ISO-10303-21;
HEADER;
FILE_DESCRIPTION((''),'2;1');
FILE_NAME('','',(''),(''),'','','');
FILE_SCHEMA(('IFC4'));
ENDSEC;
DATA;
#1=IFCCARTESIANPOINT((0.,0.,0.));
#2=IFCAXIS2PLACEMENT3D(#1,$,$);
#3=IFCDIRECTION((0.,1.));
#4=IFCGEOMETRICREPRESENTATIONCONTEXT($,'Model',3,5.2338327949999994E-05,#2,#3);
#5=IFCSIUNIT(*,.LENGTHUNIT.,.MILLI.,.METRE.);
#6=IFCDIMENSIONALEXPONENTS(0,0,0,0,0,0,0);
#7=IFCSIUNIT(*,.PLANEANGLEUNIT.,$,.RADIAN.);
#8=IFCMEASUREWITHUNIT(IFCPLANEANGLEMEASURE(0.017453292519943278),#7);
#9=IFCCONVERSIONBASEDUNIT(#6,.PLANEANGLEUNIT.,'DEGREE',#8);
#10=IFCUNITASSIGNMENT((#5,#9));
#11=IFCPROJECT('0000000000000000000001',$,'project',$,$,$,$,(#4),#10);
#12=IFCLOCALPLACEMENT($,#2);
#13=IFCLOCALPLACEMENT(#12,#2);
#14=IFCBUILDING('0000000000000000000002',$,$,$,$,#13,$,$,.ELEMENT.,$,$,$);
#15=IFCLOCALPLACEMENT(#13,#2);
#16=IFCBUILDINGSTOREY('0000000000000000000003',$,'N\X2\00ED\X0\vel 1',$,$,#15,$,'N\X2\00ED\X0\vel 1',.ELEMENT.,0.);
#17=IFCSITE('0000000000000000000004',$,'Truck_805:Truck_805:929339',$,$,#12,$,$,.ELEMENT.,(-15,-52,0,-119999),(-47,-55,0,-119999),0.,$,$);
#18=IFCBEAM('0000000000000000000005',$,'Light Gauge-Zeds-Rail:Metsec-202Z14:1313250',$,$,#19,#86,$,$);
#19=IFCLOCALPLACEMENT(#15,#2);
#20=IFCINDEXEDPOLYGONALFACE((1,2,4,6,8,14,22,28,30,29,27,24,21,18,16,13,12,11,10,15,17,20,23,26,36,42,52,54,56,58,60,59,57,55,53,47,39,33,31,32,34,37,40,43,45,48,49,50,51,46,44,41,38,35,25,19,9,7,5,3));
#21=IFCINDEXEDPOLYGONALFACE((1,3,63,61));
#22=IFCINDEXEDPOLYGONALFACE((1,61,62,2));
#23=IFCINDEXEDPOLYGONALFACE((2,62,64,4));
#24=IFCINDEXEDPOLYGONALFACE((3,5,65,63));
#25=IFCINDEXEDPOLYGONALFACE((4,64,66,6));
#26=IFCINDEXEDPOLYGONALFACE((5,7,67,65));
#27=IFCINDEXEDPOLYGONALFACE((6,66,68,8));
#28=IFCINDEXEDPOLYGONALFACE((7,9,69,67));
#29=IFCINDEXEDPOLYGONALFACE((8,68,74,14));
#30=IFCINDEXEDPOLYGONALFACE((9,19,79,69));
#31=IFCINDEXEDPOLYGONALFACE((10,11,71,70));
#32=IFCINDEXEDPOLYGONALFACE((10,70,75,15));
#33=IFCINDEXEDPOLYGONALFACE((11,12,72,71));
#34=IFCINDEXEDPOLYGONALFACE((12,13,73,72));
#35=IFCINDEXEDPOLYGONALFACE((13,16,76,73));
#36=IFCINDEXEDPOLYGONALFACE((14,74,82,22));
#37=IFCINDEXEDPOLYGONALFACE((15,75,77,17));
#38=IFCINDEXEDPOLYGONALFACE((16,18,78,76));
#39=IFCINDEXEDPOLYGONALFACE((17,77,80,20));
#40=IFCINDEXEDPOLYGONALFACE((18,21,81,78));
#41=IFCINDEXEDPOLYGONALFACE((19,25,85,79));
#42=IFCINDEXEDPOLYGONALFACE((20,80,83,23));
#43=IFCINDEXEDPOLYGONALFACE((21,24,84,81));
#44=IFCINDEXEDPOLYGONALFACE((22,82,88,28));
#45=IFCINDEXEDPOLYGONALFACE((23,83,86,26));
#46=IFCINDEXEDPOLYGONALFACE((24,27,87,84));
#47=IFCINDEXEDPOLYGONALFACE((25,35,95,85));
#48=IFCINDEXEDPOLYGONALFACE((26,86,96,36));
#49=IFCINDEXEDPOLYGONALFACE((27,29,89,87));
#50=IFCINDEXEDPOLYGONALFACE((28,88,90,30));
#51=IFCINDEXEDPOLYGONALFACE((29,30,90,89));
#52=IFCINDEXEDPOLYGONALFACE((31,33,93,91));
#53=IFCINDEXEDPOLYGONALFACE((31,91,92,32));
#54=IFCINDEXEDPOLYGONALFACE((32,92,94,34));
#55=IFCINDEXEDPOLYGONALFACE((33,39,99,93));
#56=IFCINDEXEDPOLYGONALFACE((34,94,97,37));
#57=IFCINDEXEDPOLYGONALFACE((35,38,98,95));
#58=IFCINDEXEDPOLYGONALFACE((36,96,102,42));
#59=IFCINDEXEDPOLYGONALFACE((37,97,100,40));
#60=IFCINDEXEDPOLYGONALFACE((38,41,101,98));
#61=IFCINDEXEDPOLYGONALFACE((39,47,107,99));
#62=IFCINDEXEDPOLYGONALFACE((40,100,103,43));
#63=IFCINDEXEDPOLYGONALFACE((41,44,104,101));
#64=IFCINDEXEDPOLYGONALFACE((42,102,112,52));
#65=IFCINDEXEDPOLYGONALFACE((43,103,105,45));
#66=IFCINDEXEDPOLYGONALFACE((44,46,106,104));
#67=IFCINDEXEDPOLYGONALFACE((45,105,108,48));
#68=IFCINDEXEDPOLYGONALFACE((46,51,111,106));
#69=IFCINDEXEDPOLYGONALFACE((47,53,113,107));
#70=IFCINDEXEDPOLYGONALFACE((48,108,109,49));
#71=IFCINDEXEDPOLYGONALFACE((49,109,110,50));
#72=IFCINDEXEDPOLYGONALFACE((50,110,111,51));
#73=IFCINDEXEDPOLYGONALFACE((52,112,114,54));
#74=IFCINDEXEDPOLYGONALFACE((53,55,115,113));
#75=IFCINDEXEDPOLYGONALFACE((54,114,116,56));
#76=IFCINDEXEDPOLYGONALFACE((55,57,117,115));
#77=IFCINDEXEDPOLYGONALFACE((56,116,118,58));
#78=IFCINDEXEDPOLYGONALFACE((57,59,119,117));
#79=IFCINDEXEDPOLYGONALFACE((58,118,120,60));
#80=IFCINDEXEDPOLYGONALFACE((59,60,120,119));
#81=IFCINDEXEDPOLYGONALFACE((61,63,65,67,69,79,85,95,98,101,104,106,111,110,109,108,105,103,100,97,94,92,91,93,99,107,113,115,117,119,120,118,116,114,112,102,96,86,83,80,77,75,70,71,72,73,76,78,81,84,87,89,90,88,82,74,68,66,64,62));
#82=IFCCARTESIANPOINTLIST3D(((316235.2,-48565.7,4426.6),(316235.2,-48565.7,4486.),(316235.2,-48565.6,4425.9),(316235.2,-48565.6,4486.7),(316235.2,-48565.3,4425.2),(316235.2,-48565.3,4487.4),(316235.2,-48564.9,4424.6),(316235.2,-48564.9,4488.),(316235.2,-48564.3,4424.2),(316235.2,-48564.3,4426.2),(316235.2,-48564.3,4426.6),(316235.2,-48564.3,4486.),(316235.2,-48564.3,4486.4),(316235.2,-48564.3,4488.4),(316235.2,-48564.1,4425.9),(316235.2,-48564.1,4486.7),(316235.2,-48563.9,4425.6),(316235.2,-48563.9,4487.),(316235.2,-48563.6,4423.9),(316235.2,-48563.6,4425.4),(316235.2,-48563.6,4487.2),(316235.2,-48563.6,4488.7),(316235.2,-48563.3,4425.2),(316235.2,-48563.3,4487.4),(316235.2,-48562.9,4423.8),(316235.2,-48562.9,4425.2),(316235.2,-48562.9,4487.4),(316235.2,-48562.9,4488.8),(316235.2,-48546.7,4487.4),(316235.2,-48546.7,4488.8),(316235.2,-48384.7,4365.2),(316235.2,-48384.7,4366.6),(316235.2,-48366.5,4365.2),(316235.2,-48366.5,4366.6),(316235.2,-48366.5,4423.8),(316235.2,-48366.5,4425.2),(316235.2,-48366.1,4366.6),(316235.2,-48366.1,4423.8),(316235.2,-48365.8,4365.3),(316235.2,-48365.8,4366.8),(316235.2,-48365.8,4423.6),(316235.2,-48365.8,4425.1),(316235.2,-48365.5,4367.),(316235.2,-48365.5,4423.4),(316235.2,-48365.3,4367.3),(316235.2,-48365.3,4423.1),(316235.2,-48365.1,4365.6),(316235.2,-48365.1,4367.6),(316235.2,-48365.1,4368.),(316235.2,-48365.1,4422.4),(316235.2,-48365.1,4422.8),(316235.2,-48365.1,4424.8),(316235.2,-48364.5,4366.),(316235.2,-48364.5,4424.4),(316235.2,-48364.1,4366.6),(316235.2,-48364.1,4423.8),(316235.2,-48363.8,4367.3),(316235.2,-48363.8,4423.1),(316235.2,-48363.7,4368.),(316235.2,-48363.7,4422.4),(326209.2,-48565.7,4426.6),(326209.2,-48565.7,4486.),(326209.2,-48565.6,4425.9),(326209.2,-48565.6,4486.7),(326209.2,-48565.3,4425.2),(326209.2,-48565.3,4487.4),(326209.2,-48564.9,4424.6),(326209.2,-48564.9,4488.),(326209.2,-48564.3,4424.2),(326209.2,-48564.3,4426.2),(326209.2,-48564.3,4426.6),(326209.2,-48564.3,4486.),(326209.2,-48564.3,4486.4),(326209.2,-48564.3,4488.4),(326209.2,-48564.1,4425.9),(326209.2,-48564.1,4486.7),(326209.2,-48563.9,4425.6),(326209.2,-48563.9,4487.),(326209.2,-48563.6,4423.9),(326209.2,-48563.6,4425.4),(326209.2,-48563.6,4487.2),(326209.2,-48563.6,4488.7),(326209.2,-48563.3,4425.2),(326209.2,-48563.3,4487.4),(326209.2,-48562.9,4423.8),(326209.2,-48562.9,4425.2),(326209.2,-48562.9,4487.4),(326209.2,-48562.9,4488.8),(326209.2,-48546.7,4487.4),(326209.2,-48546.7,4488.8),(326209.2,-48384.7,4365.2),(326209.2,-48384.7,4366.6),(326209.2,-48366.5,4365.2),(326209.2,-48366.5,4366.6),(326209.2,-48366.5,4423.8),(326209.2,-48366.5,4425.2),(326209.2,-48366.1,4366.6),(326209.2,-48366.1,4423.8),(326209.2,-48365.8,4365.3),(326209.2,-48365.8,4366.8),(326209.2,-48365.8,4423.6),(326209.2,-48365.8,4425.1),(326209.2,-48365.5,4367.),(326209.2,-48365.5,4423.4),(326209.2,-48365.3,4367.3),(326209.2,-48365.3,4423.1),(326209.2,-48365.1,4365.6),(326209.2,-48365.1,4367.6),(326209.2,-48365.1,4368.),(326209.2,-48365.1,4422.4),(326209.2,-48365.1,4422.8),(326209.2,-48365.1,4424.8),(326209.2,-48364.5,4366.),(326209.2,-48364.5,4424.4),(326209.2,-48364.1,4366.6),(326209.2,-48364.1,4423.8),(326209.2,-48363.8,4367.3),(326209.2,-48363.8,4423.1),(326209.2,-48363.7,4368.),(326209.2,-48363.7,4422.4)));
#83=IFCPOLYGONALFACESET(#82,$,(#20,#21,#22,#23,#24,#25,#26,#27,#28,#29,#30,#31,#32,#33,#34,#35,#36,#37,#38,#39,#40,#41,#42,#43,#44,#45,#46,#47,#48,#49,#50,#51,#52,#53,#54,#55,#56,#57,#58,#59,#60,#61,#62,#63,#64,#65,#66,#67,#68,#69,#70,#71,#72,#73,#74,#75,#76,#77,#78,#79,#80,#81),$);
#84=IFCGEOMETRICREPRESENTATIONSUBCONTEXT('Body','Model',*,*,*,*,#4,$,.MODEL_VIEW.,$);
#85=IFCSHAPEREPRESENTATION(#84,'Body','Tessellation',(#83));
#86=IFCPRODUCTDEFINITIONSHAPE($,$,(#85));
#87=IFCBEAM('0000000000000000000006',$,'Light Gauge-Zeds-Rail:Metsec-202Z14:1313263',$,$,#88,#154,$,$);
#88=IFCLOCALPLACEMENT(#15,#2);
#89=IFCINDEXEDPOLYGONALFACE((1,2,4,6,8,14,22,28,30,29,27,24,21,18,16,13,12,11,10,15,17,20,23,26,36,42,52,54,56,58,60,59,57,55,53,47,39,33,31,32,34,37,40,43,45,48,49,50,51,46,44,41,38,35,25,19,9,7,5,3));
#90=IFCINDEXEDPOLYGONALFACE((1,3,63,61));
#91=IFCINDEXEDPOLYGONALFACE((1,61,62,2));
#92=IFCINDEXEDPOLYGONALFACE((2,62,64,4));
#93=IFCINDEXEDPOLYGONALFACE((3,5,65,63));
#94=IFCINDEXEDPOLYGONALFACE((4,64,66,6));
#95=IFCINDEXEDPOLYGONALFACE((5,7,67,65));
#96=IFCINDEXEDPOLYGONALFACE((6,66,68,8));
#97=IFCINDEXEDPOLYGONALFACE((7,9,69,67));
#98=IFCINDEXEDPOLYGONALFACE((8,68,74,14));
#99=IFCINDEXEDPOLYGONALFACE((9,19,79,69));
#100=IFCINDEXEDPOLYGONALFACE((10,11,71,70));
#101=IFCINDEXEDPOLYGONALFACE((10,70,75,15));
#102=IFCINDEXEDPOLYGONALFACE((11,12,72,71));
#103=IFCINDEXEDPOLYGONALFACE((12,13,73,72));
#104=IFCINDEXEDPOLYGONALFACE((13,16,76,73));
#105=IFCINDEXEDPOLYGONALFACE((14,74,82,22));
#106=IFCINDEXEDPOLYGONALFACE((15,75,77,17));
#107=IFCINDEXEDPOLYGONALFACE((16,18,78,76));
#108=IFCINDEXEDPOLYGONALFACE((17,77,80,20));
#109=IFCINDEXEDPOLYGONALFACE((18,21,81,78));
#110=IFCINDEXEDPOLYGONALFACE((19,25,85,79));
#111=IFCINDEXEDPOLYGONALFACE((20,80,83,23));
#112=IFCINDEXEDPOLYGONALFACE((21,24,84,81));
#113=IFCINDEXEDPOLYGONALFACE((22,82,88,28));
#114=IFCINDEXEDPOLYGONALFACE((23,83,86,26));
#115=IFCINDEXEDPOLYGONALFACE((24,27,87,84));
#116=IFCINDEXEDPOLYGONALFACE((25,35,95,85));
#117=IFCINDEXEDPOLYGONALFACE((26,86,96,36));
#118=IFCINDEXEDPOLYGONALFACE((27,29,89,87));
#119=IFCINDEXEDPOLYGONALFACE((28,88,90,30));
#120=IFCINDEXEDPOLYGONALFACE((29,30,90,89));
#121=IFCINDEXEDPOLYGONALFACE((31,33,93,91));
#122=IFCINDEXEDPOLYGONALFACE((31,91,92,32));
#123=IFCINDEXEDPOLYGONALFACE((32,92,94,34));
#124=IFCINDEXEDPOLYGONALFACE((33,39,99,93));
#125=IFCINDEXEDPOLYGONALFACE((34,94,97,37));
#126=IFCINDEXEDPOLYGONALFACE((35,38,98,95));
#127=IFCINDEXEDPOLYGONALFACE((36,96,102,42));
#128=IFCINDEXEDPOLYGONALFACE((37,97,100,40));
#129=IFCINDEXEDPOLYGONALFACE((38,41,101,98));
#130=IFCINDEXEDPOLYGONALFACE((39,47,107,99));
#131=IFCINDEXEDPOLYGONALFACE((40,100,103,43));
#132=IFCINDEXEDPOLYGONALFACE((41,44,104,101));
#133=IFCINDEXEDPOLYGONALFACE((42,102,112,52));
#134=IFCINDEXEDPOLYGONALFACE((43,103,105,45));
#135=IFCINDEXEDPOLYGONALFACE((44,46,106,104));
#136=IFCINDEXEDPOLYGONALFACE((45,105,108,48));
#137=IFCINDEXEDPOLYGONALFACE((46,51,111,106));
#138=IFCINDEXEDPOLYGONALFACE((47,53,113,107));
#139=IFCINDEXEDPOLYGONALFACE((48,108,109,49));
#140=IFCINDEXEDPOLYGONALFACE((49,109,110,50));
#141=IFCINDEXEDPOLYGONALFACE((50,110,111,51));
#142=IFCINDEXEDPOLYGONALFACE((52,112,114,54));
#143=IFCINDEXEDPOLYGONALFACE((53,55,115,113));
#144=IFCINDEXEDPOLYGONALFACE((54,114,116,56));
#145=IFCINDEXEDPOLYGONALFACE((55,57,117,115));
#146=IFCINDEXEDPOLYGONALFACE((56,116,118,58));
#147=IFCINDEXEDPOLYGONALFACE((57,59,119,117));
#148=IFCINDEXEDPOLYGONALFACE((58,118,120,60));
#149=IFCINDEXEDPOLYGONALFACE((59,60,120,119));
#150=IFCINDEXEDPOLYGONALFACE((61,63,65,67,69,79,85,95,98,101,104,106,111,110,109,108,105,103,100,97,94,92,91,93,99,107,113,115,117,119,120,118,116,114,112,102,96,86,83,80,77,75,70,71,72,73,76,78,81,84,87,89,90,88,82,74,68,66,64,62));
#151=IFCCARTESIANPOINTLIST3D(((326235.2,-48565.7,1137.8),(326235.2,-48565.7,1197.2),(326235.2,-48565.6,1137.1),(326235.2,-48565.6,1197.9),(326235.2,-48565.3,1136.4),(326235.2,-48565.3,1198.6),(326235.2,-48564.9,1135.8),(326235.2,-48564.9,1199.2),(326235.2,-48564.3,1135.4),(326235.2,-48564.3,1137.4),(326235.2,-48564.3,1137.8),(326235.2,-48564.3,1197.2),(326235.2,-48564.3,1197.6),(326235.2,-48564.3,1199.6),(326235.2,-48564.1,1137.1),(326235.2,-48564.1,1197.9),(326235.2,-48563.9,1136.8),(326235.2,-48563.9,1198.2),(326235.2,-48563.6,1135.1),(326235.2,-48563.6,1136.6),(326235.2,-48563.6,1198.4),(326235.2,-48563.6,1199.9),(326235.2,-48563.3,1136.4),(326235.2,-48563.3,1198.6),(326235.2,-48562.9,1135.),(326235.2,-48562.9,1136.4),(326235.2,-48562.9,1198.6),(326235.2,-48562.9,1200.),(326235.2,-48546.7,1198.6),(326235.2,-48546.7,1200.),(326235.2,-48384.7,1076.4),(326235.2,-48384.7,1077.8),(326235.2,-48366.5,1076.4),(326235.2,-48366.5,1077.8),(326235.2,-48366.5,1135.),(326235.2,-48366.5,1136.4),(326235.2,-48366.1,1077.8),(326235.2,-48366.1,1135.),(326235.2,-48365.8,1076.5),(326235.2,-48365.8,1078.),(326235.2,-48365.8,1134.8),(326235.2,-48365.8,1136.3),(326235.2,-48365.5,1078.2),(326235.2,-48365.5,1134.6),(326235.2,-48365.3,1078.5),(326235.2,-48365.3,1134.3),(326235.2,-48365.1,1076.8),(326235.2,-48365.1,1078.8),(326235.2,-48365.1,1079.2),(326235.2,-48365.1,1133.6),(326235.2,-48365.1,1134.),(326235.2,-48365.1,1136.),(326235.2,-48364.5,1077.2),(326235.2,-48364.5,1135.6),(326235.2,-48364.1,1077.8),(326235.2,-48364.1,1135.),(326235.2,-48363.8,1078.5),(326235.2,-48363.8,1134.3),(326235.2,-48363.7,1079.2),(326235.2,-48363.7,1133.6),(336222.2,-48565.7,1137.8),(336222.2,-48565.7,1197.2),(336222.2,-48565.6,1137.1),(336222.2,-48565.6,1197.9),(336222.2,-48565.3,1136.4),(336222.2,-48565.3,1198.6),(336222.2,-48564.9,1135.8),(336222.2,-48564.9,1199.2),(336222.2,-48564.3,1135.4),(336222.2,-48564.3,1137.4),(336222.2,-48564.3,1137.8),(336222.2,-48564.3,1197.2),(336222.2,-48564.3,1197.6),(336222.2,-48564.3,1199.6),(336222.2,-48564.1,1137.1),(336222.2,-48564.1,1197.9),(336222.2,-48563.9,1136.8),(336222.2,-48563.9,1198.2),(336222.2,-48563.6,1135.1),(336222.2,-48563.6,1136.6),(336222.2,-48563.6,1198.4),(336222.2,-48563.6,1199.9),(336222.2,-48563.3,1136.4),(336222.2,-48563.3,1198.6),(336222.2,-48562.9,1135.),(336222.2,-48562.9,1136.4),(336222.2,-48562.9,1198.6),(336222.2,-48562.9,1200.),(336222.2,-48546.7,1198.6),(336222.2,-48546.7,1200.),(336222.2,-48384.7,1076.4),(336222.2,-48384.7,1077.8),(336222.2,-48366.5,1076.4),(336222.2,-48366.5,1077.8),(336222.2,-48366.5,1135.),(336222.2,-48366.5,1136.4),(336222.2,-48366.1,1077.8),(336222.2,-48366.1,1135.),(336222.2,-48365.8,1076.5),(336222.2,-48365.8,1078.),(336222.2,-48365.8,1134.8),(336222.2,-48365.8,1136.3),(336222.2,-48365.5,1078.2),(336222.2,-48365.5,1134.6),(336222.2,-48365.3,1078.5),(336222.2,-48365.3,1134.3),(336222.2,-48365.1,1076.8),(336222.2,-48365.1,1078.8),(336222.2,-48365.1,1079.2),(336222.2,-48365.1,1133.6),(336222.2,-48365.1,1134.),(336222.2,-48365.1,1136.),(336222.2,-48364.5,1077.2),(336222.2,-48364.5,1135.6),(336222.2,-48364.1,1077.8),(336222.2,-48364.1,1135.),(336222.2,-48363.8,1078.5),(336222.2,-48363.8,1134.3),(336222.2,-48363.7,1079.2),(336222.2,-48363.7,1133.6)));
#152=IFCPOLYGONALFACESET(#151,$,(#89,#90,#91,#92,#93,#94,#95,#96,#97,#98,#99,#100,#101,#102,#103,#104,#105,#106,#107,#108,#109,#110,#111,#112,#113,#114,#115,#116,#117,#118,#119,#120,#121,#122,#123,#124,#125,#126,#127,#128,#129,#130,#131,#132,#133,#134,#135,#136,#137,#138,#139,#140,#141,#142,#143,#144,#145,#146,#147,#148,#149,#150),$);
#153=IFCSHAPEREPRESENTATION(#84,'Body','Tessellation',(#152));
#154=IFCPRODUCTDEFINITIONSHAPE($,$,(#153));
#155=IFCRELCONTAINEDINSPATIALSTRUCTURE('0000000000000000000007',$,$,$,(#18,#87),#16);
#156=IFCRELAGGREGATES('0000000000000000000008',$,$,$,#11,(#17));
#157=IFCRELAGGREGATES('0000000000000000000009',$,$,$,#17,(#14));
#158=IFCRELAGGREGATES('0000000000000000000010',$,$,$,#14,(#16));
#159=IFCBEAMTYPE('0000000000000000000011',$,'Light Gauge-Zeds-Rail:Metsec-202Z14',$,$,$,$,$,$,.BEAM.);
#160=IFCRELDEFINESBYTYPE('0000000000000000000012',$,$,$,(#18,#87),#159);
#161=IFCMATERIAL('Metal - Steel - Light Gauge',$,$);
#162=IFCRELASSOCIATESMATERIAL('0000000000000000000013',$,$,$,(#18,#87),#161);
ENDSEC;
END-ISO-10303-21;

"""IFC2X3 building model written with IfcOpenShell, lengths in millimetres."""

from ifc_helpers import new_model, entity, si_unit, converted_unit, direction, frame, frame_2d, origin, place, context, subcontext, project, spatial, polyline, circle_curve, parameter, trimmed, segment, composite_curve, outline, extrude, material, type_object, element, save


model = new_model("IFC2X3")

# Units and contexts
model_context = context("Model", 3, precision=5.2338327949999994e-05, world=origin(), true_north=direction((0.0, 1.0)))
body_context = subcontext(model_context, "Body", "Model", "MODEL_VIEW")
ifc_project = project(units=[si_unit("LENGTHUNIT", "METRE", prefix="MILLI"), converted_unit("PLANEANGLEUNIT", "DEGREE", entity("IfcPlaneAngleMeasure", 0.017453292519943278), si_unit("PLANEANGLEUNIT", "RADIAN"), dimensions=[0, 0, 0, 0, 0, 0, 0])], contexts=[model_context])

# Site, building, storey
site_placement = place(None, origin())
site = spatial("IfcSite", under=ifc_project, at=site_placement, Name="Truck_805:Truck_805:929339", CompositionType="ELEMENT", RefLatitude=(-15, -52, 0, -119999), RefLongitude=(-47, -55, 0, -119999), RefElevation=0.0)
building_placement = place(site_placement, origin())
building = spatial("IfcBuilding", under=site, at=building_placement, CompositionType="ELEMENT")
storey_placement = place(building_placement, origin())
storey = spatial("IfcBuildingStorey", under=building, at=storey_placement, Name="Nível 1", LongName="Nível 1", CompositionType="ELEMENT", Elevation=0.0)

# Beams
ifc_material_1 = material(Name="Metal - Steel - Light Gauge")
beam_type_1 = type_object("IfcBeamType", Name="Light Gauge-Zeds-Rail:Metsec-202Z14", PredefinedType="BEAM")
beam_1_placement = place(storey_placement, frame((316222.2, -48465.6, 4488.8)))
element("IfcBeam", 1, at=beam_1_placement, inside=storey, type_object=beam_type_1, material=ifc_material_1, Name="Light Gauge-Zeds-Rail:Metsec-202Z14:1313250", context=body_context, shape_type="SweptSolid", body=[
    extrude(outline(composite_curve([segment(polyline([(-60.0, -100.8), (-0.6, -100.8)]), True, "CONTINUOUS"), segment(trimmed(circle_curve(frame_2d((-0.6, -98.0), x_axis=(0.0, -1.0)), 2.8), [parameter(0.0)], [parameter(90.0)], True, "PARAMETER"), True, "CONTINUOUS"), segment(polyline([(2.2, -98.0), (2.2, 98.4)]), True, "CONTINUOUS"), segment(trimmed(circle_curve(frame_2d((3.6, 98.4), x_axis=(-1.0, 0.0)), 1.4), [parameter(270.0)], [parameter(0.0)], True, "PARAMETER"), False, "CONTINUOUS"), segment(polyline([(3.6, 99.8), (58.0, 99.8)]), True, "CONTINUOUS"), segment(trimmed(circle_curve(frame_2d((58.0, 98.4), x_axis=(0.0, 1.0)), 1.4), [parameter(270.0)], [parameter(0.0)], True, "PARAMETER"), False, "CONTINUOUS"), segment(polyline([(59.4, 98.4), (59.4, 80.2)]), True, "CONTINUOUS"), segment(polyline([(59.4, 80.2), (60.8, 80.2)]), True, "CONTINUOUS"), segment(polyline([(60.8, 80.2), (60.8, 98.4)]), True, "CONTINUOUS"), segment(trimmed(circle_curve(frame_2d((58.0, 98.4), x_axis=(1.0, 0.0)), 2.8), [parameter(0.0)], [parameter(90.0)], True, "PARAMETER"), True, "CONTINUOUS"), segment(polyline([(58.0, 101.2), (3.6, 101.2)]), True, "CONTINUOUS"), segment(trimmed(circle_curve(frame_2d((3.6, 98.4), x_axis=(0.0, 1.0)), 2.8), [parameter(0.0)], [parameter(90.0)], True, "PARAMETER"), True, "CONTINUOUS"), segment(polyline([(0.8, 98.4), (0.8, -98.0)]), True, "CONTINUOUS"), segment(trimmed(circle_curve(frame_2d((-0.6, -98.0), x_axis=(1.0, 0.0)), 1.4), [parameter(270.0)], [parameter(0.0)], True, "PARAMETER"), False, "CONTINUOUS"), segment(polyline([(-0.6, -99.4), (-60.0, -99.4)]), True, "CONTINUOUS"), segment(trimmed(circle_curve(frame_2d((-60.0, -98.0), x_axis=(0.0, -1.0)), 1.4), [parameter(270.0)], [parameter(0.0)], True, "PARAMETER"), False, "CONTINUOUS"), segment(polyline([(-61.4, -98.0), (-61.4, -81.8)]), True, "CONTINUOUS"), segment(polyline([(-61.4, -81.8), (-62.8, -81.8)]), True, "CONTINUOUS"), segment(polyline([(-62.8, -81.8), (-62.8, -98.0)]), True, "CONTINUOUS"), segment(trimmed(circle_curve(frame_2d((-60.0, -98.0), x_axis=(-1.0, 0.0)), 2.8), [parameter(0.0)], [parameter(90.0)], True, "PARAMETER"), True, "CONTINUOUS")], self_intersect=False)), frame((13.0, 0.7, -62.8), z_axis=(1.0, 0.0, 0.0), x_axis=(0.0, 0.0, -1.0)), (0.0, 0.0, 1.0), 9974.0),
])
beam_2_placement = place(storey_placement, frame((326222.2, -48465.6, 1200.0)))
element("IfcBeam", 2, at=beam_2_placement, inside=storey, type_object=beam_type_1, material=ifc_material_1, Name="Light Gauge-Zeds-Rail:Metsec-202Z14:1313263", context=body_context, shape_type="SweptSolid", body=[
    extrude(outline(composite_curve([segment(polyline([(-60.0, -100.8), (-0.6, -100.8)]), True, "CONTINUOUS"), segment(trimmed(circle_curve(frame_2d((-0.6, -98.0), x_axis=(0.0, -1.0)), 2.8), [parameter(0.0)], [parameter(90.0)], True, "PARAMETER"), True, "CONTINUOUS"), segment(polyline([(2.2, -98.0), (2.2, 98.4)]), True, "CONTINUOUS"), segment(trimmed(circle_curve(frame_2d((3.6, 98.4), x_axis=(-1.0, 0.0)), 1.4), [parameter(270.0)], [parameter(0.0)], True, "PARAMETER"), False, "CONTINUOUS"), segment(polyline([(3.6, 99.8), (58.0, 99.8)]), True, "CONTINUOUS"), segment(trimmed(circle_curve(frame_2d((58.0, 98.4), x_axis=(0.0, 1.0)), 1.4), [parameter(270.0)], [parameter(0.0)], True, "PARAMETER"), False, "CONTINUOUS"), segment(polyline([(59.4, 98.4), (59.4, 80.2)]), True, "CONTINUOUS"), segment(polyline([(59.4, 80.2), (60.8, 80.2)]), True, "CONTINUOUS"), segment(polyline([(60.8, 80.2), (60.8, 98.4)]), True, "CONTINUOUS"), segment(trimmed(circle_curve(frame_2d((58.0, 98.4), x_axis=(1.0, 0.0)), 2.8), [parameter(0.0)], [parameter(90.0)], True, "PARAMETER"), True, "CONTINUOUS"), segment(polyline([(58.0, 101.2), (3.6, 101.2)]), True, "CONTINUOUS"), segment(trimmed(circle_curve(frame_2d((3.6, 98.4), x_axis=(0.0, 1.0)), 2.8), [parameter(0.0)], [parameter(90.0)], True, "PARAMETER"), True, "CONTINUOUS"), segment(polyline([(0.8, 98.4), (0.8, -98.0)]), True, "CONTINUOUS"), segment(trimmed(circle_curve(frame_2d((-0.6, -98.0), x_axis=(1.0, 0.0)), 1.4), [parameter(270.0)], [parameter(0.0)], True, "PARAMETER"), False, "CONTINUOUS"), segment(polyline([(-0.6, -99.4), (-60.0, -99.4)]), True, "CONTINUOUS"), segment(trimmed(circle_curve(frame_2d((-60.0, -98.0), x_axis=(0.0, -1.0)), 1.4), [parameter(270.0)], [parameter(0.0)], True, "PARAMETER"), False, "CONTINUOUS"), segment(polyline([(-61.4, -98.0), (-61.4, -81.8)]), True, "CONTINUOUS"), segment(polyline([(-61.4, -81.8), (-62.8, -81.8)]), True, "CONTINUOUS"), segment(polyline([(-62.8, -81.8), (-62.8, -98.0)]), True, "CONTINUOUS"), segment(trimmed(circle_curve(frame_2d((-60.0, -98.0), x_axis=(-1.0, 0.0)), 2.8), [parameter(0.0)], [parameter(90.0)], True, "PARAMETER"), True, "CONTINUOUS")], self_intersect=False)), frame((13.0, 0.7, -62.8), z_axis=(1.0, 0.0, 0.0), x_axis=(0.0, 0.0, -1.0)), (0.0, 0.0, 1.0), 9987.0),
])

save(model, "model.ifc")
